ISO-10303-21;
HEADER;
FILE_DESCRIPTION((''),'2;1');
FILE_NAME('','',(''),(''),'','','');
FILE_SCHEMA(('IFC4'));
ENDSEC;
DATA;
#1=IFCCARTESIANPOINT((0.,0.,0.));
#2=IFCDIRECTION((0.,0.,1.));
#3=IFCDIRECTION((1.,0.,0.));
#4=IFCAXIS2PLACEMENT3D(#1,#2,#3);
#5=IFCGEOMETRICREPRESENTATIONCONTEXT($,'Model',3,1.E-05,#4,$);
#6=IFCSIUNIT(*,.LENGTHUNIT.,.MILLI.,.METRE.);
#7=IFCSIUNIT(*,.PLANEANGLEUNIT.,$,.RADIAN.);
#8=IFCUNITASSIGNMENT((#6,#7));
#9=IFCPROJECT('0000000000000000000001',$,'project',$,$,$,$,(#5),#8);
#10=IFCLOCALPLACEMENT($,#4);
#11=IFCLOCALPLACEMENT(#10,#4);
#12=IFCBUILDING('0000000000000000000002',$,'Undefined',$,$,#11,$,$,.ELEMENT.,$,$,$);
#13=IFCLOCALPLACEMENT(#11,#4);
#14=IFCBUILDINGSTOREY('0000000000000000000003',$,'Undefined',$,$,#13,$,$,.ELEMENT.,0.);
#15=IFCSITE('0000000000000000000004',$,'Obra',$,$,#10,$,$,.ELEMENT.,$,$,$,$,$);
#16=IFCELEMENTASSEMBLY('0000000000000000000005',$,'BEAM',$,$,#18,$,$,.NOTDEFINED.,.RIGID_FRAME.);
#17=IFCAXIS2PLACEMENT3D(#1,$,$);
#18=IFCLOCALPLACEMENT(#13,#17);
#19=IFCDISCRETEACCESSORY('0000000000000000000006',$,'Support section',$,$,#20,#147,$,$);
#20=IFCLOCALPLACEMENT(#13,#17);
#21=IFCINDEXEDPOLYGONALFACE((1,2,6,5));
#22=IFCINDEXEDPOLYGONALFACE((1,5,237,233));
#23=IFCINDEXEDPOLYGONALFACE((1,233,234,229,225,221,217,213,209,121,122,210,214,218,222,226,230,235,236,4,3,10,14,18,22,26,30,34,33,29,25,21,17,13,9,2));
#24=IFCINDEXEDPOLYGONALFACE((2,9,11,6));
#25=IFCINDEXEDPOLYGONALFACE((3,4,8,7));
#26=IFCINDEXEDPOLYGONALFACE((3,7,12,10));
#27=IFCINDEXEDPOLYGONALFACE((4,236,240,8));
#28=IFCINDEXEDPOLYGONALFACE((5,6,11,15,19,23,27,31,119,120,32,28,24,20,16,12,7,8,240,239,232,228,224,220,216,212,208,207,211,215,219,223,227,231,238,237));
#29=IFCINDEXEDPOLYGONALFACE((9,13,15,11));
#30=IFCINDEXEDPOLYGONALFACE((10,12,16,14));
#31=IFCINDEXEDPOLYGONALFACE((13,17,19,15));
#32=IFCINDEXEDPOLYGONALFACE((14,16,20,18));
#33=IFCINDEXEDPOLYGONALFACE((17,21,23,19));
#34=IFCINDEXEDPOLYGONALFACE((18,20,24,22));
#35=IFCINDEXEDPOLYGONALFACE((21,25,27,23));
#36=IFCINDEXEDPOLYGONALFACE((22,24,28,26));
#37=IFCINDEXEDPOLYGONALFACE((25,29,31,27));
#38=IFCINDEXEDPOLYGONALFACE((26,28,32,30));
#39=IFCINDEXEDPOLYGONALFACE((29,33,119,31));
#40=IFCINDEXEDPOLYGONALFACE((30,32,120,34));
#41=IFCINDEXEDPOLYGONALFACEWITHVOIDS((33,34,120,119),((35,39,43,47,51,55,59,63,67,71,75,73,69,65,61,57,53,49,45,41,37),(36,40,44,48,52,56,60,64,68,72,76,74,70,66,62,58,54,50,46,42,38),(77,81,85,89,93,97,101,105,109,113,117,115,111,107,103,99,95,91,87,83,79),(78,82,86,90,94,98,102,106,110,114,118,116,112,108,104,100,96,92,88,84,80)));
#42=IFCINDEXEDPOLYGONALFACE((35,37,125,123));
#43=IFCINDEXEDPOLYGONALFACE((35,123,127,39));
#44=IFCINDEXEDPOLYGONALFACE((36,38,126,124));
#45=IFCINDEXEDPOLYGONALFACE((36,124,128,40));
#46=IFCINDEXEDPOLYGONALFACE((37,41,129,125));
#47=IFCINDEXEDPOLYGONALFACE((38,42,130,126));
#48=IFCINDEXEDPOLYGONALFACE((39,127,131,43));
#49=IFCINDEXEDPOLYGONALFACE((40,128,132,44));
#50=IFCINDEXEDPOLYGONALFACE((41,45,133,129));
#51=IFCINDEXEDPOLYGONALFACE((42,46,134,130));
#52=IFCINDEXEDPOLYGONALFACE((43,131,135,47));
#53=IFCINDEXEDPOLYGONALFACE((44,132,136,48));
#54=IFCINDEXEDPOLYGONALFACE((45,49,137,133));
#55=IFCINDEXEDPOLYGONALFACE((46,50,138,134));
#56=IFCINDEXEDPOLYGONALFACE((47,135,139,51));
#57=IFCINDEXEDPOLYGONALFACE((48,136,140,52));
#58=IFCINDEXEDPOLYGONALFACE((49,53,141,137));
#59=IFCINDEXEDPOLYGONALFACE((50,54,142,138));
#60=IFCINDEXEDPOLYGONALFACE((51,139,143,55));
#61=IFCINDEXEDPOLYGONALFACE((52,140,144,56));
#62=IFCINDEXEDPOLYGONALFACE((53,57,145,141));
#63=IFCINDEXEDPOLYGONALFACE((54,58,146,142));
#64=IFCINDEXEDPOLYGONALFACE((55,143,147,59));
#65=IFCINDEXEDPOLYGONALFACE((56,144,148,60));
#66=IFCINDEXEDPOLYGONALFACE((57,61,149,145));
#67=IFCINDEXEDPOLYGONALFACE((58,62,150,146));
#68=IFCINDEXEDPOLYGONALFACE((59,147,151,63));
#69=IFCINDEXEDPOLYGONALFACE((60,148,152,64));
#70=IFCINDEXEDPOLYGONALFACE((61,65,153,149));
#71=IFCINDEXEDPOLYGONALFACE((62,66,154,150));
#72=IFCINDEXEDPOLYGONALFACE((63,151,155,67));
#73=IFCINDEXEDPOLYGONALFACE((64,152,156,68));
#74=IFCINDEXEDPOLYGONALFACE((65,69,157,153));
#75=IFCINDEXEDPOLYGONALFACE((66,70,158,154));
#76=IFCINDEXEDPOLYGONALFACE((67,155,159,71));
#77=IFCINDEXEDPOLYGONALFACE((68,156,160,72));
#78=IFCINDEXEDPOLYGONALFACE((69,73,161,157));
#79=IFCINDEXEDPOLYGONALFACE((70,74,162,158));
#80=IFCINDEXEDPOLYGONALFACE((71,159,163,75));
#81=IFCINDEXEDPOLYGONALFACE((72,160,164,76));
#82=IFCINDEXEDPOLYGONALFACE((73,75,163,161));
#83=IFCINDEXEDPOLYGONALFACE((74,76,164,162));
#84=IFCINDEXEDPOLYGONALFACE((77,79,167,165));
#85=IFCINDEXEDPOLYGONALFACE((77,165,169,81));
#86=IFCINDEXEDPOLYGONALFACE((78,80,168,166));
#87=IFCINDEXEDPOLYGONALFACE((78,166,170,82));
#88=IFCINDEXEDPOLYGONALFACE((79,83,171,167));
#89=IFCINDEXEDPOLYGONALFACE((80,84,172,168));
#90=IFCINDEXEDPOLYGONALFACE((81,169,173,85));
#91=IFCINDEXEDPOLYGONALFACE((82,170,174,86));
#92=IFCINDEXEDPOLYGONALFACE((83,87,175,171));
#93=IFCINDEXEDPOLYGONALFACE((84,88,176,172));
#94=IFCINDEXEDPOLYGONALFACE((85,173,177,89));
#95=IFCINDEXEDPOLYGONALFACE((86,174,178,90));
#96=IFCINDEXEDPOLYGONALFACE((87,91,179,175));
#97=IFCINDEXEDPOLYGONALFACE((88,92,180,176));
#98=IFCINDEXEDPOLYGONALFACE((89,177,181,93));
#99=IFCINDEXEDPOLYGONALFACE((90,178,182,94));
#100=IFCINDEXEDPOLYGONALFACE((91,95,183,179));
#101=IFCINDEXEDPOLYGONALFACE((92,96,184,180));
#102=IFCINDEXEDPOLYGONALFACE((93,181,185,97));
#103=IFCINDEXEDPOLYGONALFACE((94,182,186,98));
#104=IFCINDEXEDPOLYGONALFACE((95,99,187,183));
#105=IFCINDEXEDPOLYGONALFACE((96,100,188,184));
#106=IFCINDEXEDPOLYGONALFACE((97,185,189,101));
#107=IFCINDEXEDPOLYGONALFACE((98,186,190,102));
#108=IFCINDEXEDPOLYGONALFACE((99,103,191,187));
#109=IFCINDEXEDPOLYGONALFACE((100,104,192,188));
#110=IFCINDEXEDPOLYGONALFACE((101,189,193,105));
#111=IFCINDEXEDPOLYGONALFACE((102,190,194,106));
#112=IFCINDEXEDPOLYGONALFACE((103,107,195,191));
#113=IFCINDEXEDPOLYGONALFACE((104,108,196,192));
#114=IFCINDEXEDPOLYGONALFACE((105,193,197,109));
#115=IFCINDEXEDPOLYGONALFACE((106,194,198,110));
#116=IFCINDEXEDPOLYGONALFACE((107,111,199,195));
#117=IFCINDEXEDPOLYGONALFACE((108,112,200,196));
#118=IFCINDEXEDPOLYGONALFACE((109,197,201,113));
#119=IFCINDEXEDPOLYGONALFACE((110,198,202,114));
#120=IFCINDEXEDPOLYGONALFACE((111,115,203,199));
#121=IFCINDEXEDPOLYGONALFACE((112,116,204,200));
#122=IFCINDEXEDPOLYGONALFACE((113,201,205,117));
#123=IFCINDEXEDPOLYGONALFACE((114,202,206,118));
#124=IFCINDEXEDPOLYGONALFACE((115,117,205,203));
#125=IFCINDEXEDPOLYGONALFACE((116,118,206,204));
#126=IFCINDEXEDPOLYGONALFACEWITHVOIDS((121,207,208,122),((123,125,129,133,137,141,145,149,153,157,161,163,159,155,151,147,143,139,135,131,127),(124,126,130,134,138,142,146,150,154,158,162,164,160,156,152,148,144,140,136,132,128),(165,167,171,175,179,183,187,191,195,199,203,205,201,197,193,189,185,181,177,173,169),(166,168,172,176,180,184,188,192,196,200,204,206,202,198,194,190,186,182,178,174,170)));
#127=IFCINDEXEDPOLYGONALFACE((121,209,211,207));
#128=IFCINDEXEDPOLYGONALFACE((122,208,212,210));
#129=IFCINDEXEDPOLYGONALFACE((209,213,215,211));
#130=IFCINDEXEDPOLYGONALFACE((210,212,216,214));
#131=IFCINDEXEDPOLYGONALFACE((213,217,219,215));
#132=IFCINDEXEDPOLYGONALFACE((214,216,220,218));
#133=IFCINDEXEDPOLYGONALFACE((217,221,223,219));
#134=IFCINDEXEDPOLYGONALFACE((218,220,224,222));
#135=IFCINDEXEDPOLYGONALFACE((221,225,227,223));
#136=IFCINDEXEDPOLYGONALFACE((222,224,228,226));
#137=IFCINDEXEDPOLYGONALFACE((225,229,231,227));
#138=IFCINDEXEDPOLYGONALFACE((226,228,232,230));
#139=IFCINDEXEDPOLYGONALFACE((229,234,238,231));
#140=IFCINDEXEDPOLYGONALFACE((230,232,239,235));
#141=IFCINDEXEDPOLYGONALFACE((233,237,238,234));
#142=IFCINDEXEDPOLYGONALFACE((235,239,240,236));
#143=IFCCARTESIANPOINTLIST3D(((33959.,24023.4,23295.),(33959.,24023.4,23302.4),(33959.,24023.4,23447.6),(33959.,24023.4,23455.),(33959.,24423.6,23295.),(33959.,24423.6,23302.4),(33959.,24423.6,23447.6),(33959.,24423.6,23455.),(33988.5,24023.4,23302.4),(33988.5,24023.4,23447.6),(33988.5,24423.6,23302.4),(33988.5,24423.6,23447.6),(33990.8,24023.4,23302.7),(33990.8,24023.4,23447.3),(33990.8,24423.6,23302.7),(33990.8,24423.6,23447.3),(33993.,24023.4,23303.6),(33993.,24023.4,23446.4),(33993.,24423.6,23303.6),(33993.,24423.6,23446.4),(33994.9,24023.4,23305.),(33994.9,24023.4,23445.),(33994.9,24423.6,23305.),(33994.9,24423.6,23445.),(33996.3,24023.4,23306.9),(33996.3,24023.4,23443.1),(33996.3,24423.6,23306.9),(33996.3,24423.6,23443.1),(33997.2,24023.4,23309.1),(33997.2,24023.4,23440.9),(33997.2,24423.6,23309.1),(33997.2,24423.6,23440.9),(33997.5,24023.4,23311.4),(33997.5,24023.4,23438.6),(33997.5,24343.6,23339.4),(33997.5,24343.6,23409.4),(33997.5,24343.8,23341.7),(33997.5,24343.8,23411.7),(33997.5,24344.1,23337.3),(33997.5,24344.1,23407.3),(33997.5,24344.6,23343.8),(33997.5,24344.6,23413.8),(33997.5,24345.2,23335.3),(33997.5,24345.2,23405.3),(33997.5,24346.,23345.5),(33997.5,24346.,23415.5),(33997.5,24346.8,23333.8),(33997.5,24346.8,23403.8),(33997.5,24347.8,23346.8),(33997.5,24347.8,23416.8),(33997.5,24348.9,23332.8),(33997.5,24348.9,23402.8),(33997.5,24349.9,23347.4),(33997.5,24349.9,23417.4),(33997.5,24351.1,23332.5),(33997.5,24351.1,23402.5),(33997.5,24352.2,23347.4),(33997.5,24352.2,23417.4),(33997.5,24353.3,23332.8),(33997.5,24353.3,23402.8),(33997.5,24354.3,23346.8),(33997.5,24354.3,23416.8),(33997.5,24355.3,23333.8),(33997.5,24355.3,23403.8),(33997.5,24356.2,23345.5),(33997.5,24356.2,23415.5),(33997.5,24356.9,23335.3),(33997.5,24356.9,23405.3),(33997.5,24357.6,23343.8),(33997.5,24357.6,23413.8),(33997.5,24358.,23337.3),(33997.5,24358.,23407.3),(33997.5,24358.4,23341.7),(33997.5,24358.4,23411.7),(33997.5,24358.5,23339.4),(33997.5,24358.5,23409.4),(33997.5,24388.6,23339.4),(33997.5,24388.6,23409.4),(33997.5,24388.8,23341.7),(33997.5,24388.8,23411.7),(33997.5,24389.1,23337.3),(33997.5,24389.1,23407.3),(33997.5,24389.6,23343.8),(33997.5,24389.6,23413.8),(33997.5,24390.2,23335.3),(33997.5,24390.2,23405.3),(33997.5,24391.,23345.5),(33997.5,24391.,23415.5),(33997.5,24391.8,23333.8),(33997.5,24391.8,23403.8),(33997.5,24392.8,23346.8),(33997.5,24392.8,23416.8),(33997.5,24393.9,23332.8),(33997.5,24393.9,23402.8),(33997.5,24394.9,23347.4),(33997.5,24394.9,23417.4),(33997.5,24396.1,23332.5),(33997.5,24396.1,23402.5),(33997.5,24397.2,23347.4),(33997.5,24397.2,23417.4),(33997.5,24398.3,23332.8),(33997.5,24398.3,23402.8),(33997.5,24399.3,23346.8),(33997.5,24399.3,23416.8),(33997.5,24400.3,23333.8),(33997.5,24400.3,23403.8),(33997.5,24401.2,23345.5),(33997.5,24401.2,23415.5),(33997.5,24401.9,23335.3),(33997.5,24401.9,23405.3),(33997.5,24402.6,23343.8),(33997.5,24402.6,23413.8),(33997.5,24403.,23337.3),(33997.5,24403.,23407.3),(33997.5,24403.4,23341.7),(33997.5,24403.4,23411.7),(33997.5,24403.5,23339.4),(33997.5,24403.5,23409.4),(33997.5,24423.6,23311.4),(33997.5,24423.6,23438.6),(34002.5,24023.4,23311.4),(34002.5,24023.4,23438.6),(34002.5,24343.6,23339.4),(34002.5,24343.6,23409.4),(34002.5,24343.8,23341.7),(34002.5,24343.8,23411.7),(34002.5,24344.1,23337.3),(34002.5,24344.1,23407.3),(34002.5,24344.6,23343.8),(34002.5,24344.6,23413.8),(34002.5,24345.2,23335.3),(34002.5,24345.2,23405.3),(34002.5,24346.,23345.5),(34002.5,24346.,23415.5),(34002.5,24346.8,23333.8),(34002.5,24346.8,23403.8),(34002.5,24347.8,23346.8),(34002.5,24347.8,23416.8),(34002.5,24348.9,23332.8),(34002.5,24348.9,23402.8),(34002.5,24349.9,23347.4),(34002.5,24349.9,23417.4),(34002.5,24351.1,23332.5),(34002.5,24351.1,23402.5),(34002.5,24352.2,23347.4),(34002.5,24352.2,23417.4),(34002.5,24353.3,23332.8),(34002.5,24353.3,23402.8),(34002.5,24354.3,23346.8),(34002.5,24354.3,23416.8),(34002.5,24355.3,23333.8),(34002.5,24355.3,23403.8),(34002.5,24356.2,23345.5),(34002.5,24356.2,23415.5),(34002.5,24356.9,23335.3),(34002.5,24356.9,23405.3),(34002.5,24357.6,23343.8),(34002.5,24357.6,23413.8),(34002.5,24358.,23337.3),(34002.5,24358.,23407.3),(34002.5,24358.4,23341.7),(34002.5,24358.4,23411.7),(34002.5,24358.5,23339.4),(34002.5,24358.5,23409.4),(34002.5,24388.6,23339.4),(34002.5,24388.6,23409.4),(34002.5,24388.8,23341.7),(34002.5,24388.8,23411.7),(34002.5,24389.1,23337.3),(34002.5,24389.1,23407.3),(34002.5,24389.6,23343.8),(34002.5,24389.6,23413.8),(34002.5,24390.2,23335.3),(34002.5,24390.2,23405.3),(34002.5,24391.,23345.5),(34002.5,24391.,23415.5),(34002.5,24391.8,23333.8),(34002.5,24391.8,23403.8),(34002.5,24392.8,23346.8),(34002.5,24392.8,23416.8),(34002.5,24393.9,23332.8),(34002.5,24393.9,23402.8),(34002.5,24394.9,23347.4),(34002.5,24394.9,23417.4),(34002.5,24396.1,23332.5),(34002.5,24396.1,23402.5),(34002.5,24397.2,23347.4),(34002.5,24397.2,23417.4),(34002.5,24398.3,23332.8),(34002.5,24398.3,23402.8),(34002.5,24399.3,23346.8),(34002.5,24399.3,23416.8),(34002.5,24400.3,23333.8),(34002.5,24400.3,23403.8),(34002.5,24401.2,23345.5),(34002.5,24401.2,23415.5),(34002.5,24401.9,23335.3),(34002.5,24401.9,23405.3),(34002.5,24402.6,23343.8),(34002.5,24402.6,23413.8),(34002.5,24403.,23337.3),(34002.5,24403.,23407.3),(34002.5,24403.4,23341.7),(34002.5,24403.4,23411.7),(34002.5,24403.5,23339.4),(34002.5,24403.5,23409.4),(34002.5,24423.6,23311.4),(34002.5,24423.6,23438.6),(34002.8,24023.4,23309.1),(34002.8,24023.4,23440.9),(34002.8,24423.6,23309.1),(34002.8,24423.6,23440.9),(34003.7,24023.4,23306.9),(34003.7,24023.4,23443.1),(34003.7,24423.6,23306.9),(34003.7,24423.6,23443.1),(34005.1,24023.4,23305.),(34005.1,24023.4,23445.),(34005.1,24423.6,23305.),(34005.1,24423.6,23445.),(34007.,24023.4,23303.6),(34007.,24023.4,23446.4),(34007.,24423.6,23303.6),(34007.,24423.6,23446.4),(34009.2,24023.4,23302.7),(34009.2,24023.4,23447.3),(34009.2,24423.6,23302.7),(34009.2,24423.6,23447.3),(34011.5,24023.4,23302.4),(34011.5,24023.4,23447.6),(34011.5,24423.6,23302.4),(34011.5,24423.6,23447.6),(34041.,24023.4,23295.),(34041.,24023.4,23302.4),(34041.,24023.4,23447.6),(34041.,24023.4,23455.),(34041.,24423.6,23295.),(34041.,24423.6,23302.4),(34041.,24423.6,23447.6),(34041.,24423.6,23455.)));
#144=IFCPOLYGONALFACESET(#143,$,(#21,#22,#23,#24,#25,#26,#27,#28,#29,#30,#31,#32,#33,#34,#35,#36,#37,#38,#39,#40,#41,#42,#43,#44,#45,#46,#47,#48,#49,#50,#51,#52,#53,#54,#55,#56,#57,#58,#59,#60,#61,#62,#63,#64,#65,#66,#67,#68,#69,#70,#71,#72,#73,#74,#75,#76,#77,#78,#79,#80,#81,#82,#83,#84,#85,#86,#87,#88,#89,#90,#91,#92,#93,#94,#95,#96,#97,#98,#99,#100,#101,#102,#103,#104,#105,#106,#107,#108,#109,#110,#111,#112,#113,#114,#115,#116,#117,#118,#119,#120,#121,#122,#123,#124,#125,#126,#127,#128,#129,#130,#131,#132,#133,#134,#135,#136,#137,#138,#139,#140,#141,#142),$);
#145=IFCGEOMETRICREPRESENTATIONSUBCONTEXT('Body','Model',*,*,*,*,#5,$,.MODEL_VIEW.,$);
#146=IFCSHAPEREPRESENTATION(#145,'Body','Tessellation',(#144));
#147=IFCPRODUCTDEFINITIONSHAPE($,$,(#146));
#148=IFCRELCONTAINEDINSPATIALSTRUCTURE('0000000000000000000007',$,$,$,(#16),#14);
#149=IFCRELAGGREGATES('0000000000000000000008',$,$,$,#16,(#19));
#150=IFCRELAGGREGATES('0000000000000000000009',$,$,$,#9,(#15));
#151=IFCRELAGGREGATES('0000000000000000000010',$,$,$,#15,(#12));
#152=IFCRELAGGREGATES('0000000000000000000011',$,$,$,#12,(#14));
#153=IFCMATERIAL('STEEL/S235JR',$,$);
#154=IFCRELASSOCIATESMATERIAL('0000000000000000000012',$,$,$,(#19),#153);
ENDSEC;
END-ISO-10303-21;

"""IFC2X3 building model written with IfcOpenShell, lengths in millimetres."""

from ifc_helpers import new_model, si_unit, frame, origin_with_axes, origin_2d_with_axis, place, context, subcontext, project, spatial, circle, i_section, extrude, clip, halfspace, source, transform, mapped, material, element, aggregate, save


model = new_model("IFC2X3")

# Units and contexts
model_context = context("Model", 3, precision=1e-05, world=origin_with_axes())
body_context = subcontext(model_context, "Body", "Model", "MODEL_VIEW")
ifc_project = project(units=[si_unit("LENGTHUNIT", "METRE", prefix="MILLI"), si_unit("PLANEANGLEUNIT", "RADIAN")], contexts=[model_context])

# Site, building, storey
site_placement = place(None, origin_with_axes())
site = spatial("IfcSite", under=ifc_project, at=site_placement, Name="Obra", CompositionType="ELEMENT")
building_placement = place(site_placement, origin_with_axes())
building = spatial("IfcBuilding", under=site, at=building_placement, Name="Undefined", CompositionType="ELEMENT")
storey_placement = place(building_placement, origin_with_axes())
storey = spatial("IfcBuildingStorey", under=building, at=storey_placement, Name="Undefined", CompositionType="ELEMENT", Elevation=0.0)

# Shared definitions
ifc_material_1 = material(Name="STEEL/S235JR")

# Element assembly
assembly_1_placement = place(storey_placement, origin_with_axes())
assembly_1 = element("IfcElementAssembly", 1, at=assembly_1_placement, inside=storey, Name="BEAM", AssemblyPlace="NOTDEFINED", PredefinedType="RIGID_FRAME")

# Discrete accessory, opening
discrete_accessory_1_placement = place(assembly_1_placement, frame((34000.0, 24023.4, 23375.0), z_axis=(0.0, 0.0, 1.0), x_axis=(0.0, 1.0, 0.0)))
discrete_accessory_1 = element("IfcDiscreteAccessory", 2, at=discrete_accessory_1_placement, material=ifc_material_1, Name="Support section", context=body_context, shape_type="Clipping", body=[
    clip(extrude(i_section(OverallWidth=82.0, OverallDepth=160.0, WebThickness=5.0, FlangeThickness=7.4, FilletRadius=9.0, at=origin_2d_with_axis()), frame((400.1, 0.0, 0.0), z_axis=(-1.0, 0.0, 0.0), x_axis=(0.0, -1.0, 0.0)), (0.0, 0.0, 1.0), 400.1), halfspace(frame((400.1, 0.0, -180.0), z_axis=(-1.0, 0.0, 0.0), x_axis=(0.0, 1.0, 0.0)), True)),
])
shared_shape_1 = source(origin_with_axes(), body_context, "Body", "SweptSolid", [
    extrude(circle(Radius=7.5, at=origin_2d_with_axis()), frame((0.0, -2.6, 0.0), z_axis=(0.0, 1.0, 0.0), x_axis=(1.0, 0.0, 0.0)), (0.0, 0.0, 1.0), 5.2),
])
opening_1_placement = place(assembly_1_placement, frame((34000.0, 24373.6, 23410.0), z_axis=(0.0, -1.0, 0.0), x_axis=(0.0, 0.0, -1.0)))
element("IfcOpeningElement", 3, at=opening_1_placement, cuts=discrete_accessory_1, ObjectType="Opening", context=body_context, shape_type="MappedRepresentation", body=[
    mapped(shared_shape_1, transform((0.0, 0.0, -22.5))),
    mapped(shared_shape_1, transform((70.0, 0.0, -22.5))),
    mapped(shared_shape_1, transform((0.0, 0.0, 22.5))),
    mapped(shared_shape_1, transform((70.0, 0.0, 22.5))),
])

aggregate(assembly_1, [discrete_accessory_1])

save(model, "model.ifc")
